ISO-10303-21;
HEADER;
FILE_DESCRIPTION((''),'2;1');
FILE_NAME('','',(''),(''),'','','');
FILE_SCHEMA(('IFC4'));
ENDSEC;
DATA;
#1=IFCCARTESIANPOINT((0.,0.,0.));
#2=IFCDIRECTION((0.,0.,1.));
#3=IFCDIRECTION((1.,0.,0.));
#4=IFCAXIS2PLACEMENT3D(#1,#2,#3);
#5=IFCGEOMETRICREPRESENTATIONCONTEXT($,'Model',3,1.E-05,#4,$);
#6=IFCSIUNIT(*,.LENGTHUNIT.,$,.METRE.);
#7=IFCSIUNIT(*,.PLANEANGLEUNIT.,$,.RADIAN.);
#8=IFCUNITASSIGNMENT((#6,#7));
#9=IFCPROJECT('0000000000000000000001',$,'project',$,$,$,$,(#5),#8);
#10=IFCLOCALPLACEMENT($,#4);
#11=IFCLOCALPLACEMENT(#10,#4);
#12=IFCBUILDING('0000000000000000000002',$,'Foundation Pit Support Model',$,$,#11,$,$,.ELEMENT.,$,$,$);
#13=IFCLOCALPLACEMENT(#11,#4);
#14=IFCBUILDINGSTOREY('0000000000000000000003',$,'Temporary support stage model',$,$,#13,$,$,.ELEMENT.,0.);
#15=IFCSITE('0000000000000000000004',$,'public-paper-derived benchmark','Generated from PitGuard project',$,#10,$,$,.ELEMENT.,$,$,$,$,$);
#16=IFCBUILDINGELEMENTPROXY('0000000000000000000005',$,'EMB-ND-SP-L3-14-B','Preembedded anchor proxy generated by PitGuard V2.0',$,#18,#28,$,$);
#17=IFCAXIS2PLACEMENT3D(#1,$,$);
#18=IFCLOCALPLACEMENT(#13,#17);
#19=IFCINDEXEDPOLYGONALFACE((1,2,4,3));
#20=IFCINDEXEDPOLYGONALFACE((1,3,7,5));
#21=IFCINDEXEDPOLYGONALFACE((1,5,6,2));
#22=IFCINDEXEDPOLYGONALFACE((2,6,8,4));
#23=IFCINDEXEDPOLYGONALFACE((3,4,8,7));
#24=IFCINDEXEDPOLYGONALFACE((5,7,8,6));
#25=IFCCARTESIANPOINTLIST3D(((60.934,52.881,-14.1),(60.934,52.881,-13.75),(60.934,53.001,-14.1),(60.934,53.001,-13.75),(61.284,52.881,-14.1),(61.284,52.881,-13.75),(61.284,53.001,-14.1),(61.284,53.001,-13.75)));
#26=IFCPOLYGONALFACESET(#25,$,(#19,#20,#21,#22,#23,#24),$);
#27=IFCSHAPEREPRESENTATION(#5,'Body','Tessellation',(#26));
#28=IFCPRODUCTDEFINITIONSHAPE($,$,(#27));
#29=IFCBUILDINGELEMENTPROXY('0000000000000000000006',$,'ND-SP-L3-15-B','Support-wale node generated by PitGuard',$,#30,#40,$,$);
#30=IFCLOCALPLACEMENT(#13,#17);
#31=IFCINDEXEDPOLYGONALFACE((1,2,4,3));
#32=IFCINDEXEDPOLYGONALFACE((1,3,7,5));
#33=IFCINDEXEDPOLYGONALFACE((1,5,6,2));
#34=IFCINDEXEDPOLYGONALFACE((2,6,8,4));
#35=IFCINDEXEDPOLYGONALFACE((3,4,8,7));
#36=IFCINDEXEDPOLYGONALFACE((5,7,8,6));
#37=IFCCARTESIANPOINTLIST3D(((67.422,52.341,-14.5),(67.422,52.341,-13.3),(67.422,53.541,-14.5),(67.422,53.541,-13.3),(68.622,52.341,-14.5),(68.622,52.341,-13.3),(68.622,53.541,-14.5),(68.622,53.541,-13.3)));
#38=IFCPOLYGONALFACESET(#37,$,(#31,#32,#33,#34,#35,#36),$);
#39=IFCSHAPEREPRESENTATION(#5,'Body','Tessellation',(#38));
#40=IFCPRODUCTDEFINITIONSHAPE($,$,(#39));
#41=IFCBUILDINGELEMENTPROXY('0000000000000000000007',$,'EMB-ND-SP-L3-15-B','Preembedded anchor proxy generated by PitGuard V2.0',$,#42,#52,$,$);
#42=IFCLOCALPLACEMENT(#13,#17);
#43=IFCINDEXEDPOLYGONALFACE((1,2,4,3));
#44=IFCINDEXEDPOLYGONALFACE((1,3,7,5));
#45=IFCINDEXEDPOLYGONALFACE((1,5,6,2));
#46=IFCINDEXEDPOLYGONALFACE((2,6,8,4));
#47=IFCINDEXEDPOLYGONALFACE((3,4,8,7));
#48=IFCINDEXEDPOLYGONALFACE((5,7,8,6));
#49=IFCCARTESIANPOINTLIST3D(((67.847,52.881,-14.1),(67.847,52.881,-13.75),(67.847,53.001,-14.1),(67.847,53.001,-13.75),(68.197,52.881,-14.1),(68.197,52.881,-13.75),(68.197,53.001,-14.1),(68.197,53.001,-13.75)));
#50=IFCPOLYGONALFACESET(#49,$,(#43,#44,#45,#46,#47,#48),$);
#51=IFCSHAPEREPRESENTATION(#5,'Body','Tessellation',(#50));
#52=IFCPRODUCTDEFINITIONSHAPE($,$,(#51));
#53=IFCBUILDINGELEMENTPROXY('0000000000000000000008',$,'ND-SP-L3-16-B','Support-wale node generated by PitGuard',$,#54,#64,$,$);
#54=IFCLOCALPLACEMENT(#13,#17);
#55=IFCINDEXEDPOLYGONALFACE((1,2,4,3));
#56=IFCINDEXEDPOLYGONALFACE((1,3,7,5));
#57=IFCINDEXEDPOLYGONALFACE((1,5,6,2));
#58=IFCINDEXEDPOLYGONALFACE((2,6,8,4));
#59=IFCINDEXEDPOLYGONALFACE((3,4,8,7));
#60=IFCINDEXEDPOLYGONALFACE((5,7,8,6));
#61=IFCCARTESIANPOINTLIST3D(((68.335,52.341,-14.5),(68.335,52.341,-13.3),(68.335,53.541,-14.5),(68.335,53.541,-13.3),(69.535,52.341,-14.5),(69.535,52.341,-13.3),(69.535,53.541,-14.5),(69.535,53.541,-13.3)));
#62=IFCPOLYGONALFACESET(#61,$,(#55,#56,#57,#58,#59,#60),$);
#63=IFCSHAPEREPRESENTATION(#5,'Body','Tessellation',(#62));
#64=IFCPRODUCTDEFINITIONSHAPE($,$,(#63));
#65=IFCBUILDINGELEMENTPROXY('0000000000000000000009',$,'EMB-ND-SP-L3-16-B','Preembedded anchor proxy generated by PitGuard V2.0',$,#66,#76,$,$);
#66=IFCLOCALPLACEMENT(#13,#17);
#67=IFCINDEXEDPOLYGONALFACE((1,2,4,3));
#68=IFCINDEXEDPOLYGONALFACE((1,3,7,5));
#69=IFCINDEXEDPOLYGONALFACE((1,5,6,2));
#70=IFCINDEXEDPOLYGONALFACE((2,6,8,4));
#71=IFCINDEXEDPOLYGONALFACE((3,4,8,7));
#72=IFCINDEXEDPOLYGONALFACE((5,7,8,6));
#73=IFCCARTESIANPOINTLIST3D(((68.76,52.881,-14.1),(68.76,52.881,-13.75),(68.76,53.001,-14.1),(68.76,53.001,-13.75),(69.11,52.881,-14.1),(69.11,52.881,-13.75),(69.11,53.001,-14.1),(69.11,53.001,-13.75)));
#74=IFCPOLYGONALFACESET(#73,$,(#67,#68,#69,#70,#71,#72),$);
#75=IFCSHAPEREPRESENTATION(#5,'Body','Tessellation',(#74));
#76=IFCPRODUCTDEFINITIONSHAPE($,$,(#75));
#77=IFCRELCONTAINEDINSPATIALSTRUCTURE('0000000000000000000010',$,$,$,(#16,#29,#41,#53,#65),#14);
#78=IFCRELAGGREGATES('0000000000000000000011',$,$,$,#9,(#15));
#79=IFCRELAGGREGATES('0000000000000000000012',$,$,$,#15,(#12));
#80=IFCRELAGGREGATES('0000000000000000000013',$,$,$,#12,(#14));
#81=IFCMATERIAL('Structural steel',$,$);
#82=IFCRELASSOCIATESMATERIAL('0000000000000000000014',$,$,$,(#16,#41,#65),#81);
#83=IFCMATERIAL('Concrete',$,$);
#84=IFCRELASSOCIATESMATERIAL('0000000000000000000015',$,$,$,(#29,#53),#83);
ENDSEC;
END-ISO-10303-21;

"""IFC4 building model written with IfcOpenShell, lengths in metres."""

from ifc_helpers import new_model, si_unit, frame, origin_with_axes, origin_2d, place, context, project, spatial, rectangle, extrude, material, element, save


model = new_model("IFC4")

# Units and contexts
model_context = context("Model", 3, precision=1e-05, world=origin_with_axes())
ifc_project = project(units=[si_unit("LENGTHUNIT", "METRE"), si_unit("PLANEANGLEUNIT", "RADIAN")], contexts=[model_context])

# Site, building, storey
site_placement = place(None, origin_with_axes())
site = spatial("IfcSite", under=ifc_project, at=site_placement, Name="public-paper-derived benchmark", Description="Generated from PitGuard project", CompositionType="ELEMENT")
building_placement = place(site_placement, origin_with_axes())
building = spatial("IfcBuilding", under=site, at=building_placement, Name="Foundation Pit Support Model", CompositionType="ELEMENT")
storey_placement = place(building_placement, origin_with_axes())
storey = spatial("IfcBuildingStorey", under=building, at=storey_placement, Name="Temporary support stage model", CompositionType="ELEMENT", Elevation=0.0)

# Shared definitions
ifc_material_1 = material(Name="Structural steel")

# Shared definitions
ifc_material_2 = material(Name="Concrete")

# Building element proxies
proxy_1_placement = place(storey_placement, frame((61.109, 52.941, -14.1), z_axis=(0.0, 0.0, 1.0), x_axis=(1.0, 0.0, 0.0)))
element("IfcBuildingElementProxy", 1, at=proxy_1_placement, inside=storey, material=ifc_material_1, Name="EMB-ND-SP-L3-14-B", Description="Preembedded anchor proxy generated by PitGuard V2.0", context=model_context, shape_type="SweptSolid", body=[
    extrude(rectangle(XDim=0.35, YDim=0.12, at=origin_2d()), origin_with_axes(), (0.0, 0.0, 1.0), 0.35),
])
proxy_2_placement = place(storey_placement, frame((68.022, 52.941, -14.5), z_axis=(0.0, 0.0, 1.0), x_axis=(1.0, 0.0, 0.0)))
element("IfcBuildingElementProxy", 2, at=proxy_2_placement, inside=storey, material=ifc_material_2, Name="ND-SP-L3-15-B", Description="Support-wale node generated by PitGuard", context=model_context, shape_type="SweptSolid", body=[
    extrude(rectangle(XDim=1.2, YDim=1.2, at=origin_2d()), origin_with_axes(), (0.0, 0.0, 1.0), 1.2),
])
proxy_3_placement = place(storey_placement, frame((68.022, 52.941, -14.1), z_axis=(0.0, 0.0, 1.0), x_axis=(1.0, 0.0, 0.0)))
element("IfcBuildingElementProxy", 3, at=proxy_3_placement, inside=storey, material=ifc_material_1, Name="EMB-ND-SP-L3-15-B", Description="Preembedded anchor proxy generated by PitGuard V2.0", context=model_context, shape_type="SweptSolid", body=[
    extrude(rectangle(XDim=0.35, YDim=0.12, at=origin_2d()), origin_with_axes(), (0.0, 0.0, 1.0), 0.35),
])
proxy_4_placement = place(storey_placement, frame((68.935, 52.941, -14.5), z_axis=(0.0, 0.0, 1.0), x_axis=(1.0, 0.0, 0.0)))
element("IfcBuildingElementProxy", 4, at=proxy_4_placement, inside=storey, material=ifc_material_2, Name="ND-SP-L3-16-B", Description="Support-wale node generated by PitGuard", context=model_context, shape_type="SweptSolid", body=[
    extrude(rectangle(XDim=1.2, YDim=1.2, at=origin_2d()), origin_with_axes(), (0.0, 0.0, 1.0), 1.2),
])
proxy_5_placement = place(storey_placement, frame((68.935, 52.941, -14.1), z_axis=(0.0, 0.0, 1.0), x_axis=(1.0, 0.0, 0.0)))
element("IfcBuildingElementProxy", 5, at=proxy_5_placement, inside=storey, material=ifc_material_1, Name="EMB-ND-SP-L3-16-B", Description="Preembedded anchor proxy generated by PitGuard V2.0", context=model_context, shape_type="SweptSolid", body=[
    extrude(rectangle(XDim=0.35, YDim=0.12, at=origin_2d()), origin_with_axes(), (0.0, 0.0, 1.0), 0.35),
])

save(model, "model.ifc")
